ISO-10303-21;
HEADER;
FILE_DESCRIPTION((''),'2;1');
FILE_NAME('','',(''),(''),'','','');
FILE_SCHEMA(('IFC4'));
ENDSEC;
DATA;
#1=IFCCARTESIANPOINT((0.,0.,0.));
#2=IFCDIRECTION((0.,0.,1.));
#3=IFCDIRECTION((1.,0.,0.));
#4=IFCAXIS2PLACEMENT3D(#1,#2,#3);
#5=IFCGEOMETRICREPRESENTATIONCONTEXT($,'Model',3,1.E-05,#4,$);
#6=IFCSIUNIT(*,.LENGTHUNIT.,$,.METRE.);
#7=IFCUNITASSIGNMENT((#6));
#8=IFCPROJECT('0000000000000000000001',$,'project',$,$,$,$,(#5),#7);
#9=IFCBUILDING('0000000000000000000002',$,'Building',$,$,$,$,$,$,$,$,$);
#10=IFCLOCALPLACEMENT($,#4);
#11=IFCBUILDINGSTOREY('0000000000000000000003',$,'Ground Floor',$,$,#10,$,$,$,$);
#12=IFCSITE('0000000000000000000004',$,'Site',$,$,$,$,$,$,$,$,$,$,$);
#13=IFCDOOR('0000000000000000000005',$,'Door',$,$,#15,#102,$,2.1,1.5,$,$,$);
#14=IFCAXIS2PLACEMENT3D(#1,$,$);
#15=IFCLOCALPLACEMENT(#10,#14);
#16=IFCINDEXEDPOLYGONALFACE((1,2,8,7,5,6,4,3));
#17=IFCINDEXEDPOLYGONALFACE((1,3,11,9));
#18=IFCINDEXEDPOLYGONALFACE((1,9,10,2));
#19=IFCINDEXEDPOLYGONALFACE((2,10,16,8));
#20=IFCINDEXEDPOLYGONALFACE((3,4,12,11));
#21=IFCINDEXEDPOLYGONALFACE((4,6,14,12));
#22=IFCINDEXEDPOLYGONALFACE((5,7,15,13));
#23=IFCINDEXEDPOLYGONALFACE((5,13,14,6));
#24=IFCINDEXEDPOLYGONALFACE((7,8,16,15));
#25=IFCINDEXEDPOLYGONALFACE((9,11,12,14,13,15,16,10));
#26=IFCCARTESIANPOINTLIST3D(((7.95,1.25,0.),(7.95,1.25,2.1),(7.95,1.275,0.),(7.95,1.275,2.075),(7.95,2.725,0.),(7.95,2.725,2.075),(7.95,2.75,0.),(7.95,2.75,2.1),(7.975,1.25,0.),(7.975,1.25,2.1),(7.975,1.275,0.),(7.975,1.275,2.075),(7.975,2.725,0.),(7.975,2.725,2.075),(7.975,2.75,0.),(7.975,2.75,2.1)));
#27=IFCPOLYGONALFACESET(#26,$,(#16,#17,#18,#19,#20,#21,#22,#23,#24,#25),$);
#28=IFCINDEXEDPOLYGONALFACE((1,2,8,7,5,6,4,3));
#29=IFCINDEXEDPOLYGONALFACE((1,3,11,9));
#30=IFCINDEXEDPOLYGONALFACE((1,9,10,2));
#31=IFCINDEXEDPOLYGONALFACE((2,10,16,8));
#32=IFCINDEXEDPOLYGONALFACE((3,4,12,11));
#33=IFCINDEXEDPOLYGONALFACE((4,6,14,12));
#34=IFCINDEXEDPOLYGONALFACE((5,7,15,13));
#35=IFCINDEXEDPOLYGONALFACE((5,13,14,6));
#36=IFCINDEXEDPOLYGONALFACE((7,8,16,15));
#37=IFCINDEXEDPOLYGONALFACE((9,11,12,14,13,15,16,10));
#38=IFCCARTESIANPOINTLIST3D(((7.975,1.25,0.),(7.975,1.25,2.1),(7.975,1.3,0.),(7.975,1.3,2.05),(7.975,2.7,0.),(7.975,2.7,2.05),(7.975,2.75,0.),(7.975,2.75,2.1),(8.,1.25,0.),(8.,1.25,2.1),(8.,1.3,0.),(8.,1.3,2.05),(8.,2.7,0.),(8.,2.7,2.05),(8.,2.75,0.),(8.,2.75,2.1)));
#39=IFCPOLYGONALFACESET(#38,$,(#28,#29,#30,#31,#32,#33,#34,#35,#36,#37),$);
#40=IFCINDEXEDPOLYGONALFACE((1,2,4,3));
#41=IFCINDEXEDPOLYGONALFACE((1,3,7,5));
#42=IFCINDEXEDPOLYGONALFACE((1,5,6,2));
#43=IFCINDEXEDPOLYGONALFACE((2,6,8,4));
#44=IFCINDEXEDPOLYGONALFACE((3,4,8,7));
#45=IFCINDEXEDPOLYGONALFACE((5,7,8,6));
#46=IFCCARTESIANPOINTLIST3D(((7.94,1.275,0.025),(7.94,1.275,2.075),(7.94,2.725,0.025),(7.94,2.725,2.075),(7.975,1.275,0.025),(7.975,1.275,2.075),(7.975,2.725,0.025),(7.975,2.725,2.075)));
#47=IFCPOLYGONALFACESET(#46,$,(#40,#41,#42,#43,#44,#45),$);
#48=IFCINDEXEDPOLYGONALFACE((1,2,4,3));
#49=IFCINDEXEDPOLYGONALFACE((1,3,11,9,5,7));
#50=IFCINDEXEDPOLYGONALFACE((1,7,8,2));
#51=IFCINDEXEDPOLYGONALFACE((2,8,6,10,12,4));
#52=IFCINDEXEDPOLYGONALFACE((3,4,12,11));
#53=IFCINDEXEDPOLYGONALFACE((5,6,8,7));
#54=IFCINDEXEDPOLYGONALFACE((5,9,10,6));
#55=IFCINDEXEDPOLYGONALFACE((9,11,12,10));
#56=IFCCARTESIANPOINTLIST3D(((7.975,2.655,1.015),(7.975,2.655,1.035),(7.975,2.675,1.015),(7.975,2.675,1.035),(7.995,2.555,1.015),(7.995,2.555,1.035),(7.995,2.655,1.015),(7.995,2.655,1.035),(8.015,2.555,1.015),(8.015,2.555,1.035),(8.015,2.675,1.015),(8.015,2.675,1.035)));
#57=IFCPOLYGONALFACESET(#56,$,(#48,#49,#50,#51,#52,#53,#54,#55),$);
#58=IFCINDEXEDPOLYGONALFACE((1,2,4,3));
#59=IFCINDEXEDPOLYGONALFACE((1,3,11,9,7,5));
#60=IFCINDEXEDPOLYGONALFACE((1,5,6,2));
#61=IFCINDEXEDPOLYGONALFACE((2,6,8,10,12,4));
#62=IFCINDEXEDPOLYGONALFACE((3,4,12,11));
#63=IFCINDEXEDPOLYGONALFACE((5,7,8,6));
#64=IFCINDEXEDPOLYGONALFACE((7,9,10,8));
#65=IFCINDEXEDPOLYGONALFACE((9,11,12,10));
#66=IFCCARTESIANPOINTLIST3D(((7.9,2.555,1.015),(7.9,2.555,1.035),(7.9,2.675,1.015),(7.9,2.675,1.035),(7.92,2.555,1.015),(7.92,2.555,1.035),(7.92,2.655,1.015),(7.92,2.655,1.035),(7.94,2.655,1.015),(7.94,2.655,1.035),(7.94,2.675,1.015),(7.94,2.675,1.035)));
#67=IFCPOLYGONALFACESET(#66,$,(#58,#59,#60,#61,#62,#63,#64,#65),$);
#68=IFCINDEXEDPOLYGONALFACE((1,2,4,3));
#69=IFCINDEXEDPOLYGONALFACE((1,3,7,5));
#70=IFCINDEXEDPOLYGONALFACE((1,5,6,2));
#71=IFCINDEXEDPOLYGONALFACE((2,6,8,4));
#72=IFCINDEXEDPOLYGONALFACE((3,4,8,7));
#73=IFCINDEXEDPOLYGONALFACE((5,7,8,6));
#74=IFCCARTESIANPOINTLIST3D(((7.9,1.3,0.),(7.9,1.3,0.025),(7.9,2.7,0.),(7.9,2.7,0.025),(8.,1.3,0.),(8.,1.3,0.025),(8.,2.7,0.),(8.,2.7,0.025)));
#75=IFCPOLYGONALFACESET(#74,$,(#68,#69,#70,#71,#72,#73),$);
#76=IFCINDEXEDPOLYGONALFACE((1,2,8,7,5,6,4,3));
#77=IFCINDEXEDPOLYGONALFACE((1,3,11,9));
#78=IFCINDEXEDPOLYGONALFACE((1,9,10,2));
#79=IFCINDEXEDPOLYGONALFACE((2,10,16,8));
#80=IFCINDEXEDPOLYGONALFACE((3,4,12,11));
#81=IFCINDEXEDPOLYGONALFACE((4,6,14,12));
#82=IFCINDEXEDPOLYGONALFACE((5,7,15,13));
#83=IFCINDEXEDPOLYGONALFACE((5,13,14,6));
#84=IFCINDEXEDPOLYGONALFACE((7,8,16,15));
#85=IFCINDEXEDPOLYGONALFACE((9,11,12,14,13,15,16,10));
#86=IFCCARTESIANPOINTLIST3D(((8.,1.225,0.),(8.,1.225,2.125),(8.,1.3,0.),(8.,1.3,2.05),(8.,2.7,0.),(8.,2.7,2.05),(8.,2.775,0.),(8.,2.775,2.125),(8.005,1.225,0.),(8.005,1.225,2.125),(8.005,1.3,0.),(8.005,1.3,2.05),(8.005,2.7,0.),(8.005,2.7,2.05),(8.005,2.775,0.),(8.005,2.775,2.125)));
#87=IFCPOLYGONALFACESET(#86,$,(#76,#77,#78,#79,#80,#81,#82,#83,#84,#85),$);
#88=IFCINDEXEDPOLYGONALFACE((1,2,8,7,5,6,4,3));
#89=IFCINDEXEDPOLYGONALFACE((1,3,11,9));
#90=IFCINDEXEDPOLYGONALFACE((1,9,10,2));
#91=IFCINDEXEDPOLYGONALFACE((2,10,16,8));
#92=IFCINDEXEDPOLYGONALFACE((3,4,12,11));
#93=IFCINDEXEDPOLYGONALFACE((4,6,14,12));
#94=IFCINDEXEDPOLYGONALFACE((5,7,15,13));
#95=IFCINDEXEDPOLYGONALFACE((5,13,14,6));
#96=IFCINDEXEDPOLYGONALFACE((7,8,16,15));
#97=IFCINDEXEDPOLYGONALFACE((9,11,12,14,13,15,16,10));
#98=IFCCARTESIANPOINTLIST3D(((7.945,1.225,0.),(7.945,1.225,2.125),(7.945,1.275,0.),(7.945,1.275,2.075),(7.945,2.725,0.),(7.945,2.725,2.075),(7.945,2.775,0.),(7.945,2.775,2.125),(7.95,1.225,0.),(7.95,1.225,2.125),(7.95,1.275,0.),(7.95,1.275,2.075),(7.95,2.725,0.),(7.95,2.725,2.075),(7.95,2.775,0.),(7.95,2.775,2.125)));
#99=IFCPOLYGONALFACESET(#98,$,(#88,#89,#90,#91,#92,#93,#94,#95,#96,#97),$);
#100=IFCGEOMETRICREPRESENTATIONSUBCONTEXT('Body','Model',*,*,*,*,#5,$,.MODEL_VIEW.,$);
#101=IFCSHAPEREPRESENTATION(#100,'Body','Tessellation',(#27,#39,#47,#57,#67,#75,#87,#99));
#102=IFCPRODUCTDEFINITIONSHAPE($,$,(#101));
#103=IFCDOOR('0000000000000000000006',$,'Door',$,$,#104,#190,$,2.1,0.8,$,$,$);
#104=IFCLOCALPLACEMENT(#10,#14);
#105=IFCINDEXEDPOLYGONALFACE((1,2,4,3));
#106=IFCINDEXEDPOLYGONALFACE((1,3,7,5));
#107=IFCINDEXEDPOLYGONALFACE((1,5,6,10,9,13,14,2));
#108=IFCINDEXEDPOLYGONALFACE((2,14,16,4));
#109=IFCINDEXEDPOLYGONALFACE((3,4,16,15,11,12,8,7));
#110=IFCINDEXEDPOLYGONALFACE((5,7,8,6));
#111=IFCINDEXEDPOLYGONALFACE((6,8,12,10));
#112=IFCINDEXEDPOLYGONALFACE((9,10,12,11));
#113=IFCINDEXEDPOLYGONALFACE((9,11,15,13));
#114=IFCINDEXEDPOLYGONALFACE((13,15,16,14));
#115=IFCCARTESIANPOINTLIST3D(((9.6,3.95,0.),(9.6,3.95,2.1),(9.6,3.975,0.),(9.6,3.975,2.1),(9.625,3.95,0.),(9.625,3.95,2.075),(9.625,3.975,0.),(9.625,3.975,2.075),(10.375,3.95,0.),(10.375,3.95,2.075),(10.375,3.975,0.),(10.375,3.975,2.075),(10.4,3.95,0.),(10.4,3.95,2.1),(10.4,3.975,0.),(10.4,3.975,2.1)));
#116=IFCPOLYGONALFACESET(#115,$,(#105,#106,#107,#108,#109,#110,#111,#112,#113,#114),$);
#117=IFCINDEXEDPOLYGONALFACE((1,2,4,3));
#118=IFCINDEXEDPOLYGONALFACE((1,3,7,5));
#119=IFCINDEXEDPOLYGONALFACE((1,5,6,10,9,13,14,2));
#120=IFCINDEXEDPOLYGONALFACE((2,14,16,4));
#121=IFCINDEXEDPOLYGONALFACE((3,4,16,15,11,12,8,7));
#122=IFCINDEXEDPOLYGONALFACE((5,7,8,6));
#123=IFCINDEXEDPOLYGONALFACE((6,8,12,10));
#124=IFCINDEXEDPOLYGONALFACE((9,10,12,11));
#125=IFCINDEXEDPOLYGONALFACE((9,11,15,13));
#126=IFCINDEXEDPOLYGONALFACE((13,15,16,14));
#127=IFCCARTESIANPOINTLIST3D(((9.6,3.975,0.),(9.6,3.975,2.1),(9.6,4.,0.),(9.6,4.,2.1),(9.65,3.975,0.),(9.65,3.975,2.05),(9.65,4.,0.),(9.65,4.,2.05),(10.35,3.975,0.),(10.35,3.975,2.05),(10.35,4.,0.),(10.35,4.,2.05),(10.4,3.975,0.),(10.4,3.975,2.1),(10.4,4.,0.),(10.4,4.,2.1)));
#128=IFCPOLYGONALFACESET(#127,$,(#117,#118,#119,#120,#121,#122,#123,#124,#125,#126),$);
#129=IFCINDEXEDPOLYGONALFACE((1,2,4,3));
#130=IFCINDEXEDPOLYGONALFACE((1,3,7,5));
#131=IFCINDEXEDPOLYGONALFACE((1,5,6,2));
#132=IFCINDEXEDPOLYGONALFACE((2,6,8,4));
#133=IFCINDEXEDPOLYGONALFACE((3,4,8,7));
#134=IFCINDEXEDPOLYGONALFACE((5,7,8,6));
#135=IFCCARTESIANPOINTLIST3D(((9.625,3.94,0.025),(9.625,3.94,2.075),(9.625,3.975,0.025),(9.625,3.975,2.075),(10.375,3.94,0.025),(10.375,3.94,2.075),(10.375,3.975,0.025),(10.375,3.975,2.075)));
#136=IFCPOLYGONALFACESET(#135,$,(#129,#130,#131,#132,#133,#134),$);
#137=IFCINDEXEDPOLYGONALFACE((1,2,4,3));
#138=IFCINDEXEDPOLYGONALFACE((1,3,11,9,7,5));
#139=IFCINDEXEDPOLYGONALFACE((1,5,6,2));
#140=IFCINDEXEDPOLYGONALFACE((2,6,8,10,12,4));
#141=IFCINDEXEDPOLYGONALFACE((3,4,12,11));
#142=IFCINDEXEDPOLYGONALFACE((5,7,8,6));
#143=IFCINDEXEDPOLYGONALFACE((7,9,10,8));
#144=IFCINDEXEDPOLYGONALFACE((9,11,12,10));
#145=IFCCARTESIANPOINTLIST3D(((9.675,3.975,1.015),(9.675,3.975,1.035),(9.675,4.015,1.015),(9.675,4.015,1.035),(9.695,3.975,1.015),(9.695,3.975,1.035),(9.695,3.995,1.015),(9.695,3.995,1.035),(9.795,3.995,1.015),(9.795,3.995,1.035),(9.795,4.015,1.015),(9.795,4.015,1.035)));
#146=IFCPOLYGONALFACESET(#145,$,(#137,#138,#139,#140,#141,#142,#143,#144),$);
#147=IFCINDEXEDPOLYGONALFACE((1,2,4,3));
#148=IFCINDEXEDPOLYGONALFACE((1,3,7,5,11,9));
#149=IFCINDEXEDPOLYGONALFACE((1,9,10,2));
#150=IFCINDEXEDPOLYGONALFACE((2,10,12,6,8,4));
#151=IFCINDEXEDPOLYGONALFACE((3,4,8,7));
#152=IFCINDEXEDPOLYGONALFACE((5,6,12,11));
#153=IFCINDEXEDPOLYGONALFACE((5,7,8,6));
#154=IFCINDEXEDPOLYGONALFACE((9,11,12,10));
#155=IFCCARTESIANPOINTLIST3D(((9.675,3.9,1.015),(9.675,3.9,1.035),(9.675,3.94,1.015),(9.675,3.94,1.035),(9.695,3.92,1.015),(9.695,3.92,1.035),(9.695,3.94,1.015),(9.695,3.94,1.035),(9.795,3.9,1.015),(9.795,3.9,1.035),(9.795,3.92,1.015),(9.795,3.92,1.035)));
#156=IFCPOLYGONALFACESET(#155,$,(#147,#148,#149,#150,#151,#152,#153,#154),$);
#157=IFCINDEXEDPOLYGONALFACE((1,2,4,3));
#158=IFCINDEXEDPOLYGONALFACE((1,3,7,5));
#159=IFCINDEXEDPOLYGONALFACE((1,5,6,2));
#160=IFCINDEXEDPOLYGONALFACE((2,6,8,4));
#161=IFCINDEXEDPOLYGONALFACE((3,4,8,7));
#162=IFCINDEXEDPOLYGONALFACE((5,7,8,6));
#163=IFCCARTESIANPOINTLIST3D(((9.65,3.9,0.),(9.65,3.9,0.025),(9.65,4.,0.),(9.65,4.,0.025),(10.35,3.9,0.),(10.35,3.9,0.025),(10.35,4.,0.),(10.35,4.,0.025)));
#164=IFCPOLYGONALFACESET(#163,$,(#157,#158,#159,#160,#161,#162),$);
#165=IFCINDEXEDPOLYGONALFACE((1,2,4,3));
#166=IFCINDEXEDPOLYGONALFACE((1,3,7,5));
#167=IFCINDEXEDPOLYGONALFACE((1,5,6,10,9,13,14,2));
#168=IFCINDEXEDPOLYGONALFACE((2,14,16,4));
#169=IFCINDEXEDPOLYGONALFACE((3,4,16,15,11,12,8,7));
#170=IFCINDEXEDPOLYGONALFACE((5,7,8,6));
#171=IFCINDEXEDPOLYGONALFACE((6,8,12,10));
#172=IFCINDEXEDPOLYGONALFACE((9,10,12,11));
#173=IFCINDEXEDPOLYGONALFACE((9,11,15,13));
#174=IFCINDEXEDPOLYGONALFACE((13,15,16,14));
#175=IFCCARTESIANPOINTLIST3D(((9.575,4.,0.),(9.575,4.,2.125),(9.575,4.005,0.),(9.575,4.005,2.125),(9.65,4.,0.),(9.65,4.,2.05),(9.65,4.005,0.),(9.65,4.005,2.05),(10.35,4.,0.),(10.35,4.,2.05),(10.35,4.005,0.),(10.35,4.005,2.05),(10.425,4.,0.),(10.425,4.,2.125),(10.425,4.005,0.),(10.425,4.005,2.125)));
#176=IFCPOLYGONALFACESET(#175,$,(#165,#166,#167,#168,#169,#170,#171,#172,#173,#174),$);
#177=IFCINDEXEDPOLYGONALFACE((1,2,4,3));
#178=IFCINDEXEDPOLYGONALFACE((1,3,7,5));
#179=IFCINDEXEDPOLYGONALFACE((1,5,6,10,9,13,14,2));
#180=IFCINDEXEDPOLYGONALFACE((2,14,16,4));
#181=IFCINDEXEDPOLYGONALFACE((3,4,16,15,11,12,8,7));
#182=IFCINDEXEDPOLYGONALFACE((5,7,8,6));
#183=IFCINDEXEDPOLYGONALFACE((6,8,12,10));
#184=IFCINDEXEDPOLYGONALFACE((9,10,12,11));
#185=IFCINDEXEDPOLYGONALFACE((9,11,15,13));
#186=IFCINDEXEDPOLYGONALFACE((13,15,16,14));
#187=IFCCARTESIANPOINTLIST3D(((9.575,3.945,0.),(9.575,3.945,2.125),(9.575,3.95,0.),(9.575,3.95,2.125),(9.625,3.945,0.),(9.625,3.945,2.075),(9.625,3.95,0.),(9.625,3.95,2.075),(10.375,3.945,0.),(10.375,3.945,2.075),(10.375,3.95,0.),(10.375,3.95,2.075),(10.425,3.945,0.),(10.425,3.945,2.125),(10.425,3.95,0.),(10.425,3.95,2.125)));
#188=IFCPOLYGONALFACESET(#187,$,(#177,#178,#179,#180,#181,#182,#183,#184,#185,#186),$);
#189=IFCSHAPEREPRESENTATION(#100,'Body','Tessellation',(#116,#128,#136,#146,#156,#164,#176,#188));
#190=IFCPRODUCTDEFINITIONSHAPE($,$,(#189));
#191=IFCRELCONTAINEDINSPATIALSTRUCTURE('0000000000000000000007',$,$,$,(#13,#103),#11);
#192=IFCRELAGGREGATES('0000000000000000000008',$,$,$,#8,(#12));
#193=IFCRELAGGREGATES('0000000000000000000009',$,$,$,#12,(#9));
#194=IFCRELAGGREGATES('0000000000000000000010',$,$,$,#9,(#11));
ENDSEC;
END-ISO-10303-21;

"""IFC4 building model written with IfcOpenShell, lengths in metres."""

from ifc_helpers import new_model, si_unit, frame, origin_with_axes, place, context, subcontext, project, spatial, line, indexed_curve, outline, extrude, element, save


model = new_model("IFC4")

# Units and contexts
model_context = context("Model", 3, precision=1e-05, world=origin_with_axes())
body_context = subcontext(model_context, "Body", "Model", "MODEL_VIEW")
ifc_project = project(units=[si_unit("LENGTHUNIT", "METRE")], contexts=[model_context])

# Site, building, storey
site = spatial("IfcSite", under=ifc_project, Name="Site")
building = spatial("IfcBuilding", under=site, Name="Building")
storey_placement = place(None, origin_with_axes())
storey = spatial("IfcBuildingStorey", under=building, at=storey_placement, Name="Ground Floor")

# Doors
door_1_placement = place(storey_placement, frame((8.0, 1.25, 0.0), z_axis=(0.0, 0.0, 1.0), x_axis=(0.0, 1.0, 0.0)))
element("IfcDoor", 1, at=door_1_placement, inside=storey, Name="Door", OverallHeight=2.1, OverallWidth=1.5, context=body_context, shape_type="SweptSolid", body=[
    extrude(outline(indexed_curve([(0.0, 0.0), (0.0, 2.1), (1.5, 2.1), (1.5, 0.0), (1.475, 0.0), (1.475, 2.075), (0.025, 2.075), (0.025, 0.0)], segments=[line(1, 2, 3, 4, 5, 6, 7, 8, 1)])), frame((0.0, 0.025, 0.0), z_axis=(0.0, -1.0, 0.0), x_axis=(1.0, 0.0, 0.0)), (0.0, 0.0, -1.0), 0.025),
    extrude(outline(indexed_curve([(0.0, 0.0), (0.0, 2.1), (1.5, 2.1), (1.5, 0.0), (1.45, 0.0), (1.45, 2.05), (0.05, 2.05), (0.05, 0.0)], segments=[line(1, 2, 3, 4, 5, 6, 7, 8, 1)])), frame((0.0, 0.0, 0.0), z_axis=(0.0, -1.0, 0.0), x_axis=(1.0, 0.0, 0.0)), (0.0, 0.0, -1.0), 0.025),
    extrude(outline(indexed_curve([(0.0, 0.0), (1.45, 0.0), (1.45, 0.035), (0.0, 0.035)], segments=[line(1, 2, 3, 4, 1)])), frame((0.025, 0.025, 0.025), z_axis=(0.0, 0.0, 1.0), x_axis=(1.0, 0.0, 0.0)), (0.0, 0.0, 1.0), 2.05),
    extrude(outline(indexed_curve([(0.0, 0.0), (0.0, -0.04), (-0.12, -0.04), (-0.12, -0.02), (-0.02, -0.02), (-0.02, 0.0)], segments=[line(1, 2, 3, 4, 5, 6, 1)])), frame((1.425, 0.025, 1.015), z_axis=(0.0, 0.0, 1.0), x_axis=(1.0, 0.0, 0.0)), (0.0, 0.0, 1.0), 0.02),
    extrude(outline(indexed_curve([(0.0, 0.0), (0.0, 0.04), (-0.12, 0.04), (-0.12, 0.02), (-0.02, 0.02), (-0.02, 0.0)], segments=[line(1, 2, 3, 4, 5, 6, 1)])), frame((1.425, 0.06, 1.015), z_axis=(0.0, 0.0, 1.0), x_axis=(1.0, 0.0, 0.0)), (0.0, 0.0, 1.0), 0.02),
    extrude(outline(indexed_curve([(0.0, 0.0), (1.4, 0.0), (1.4, 0.1), (0.0, 0.1)], segments=[line(1, 2, 3, 4, 1)])), frame((0.05, 0.0, 0.0), z_axis=(0.0, 0.0, 1.0), x_axis=(1.0, 0.0, 0.0)), (0.0, 0.0, 1.0), 0.025),
    extrude(outline(indexed_curve([(0.0, 0.0), (0.0, 2.125), (1.55, 2.125), (1.55, 0.0), (1.475, 0.0), (1.475, 2.05), (0.075, 2.05), (0.075, 0.0)], segments=[line(1, 2, 3, 4, 5, 6, 7, 8, 1)])), frame((-0.025, -0.005, 0.0), z_axis=(0.0, -1.0, 0.0), x_axis=(1.0, 0.0, 0.0)), (0.0, 0.0, -1.0), 0.005),
    extrude(outline(indexed_curve([(0.0, 0.0), (0.0, 2.125), (1.55, 2.125), (1.55, 0.0), (1.5, 0.0), (1.5, 2.075), (0.05, 2.075), (0.05, 0.0)], segments=[line(1, 2, 3, 4, 5, 6, 7, 8, 1)])), frame((-0.025, 0.05, 0.0), z_axis=(0.0, -1.0, 0.0), x_axis=(1.0, 0.0, 0.0)), (0.0, 0.0, -1.0), 0.005),
])
door_2_placement = place(storey_placement, frame((10.4, 4.0, 0.0), z_axis=(0.0, 0.0, 1.0), x_axis=(-1.0, 0.0, 0.0)))
element("IfcDoor", 2, at=door_2_placement, inside=storey, Name="Door", OverallHeight=2.1, OverallWidth=0.8, context=body_context, shape_type="SweptSolid", body=[
    extrude(outline(indexed_curve([(0.0, 0.0), (0.0, 2.1), (0.8, 2.1), (0.8, 0.0), (0.775, 0.0), (0.775, 2.075), (0.025, 2.075), (0.025, 0.0)], segments=[line(1, 2, 3, 4, 5, 6, 7, 8, 1)])), frame((0.0, 0.025, 0.0), z_axis=(0.0, -1.0, 0.0), x_axis=(1.0, 0.0, 0.0)), (0.0, 0.0, -1.0), 0.025),
    extrude(outline(indexed_curve([(0.0, 0.0), (0.0, 2.1), (0.8, 2.1), (0.8, 0.0), (0.75, 0.0), (0.75, 2.05), (0.05, 2.05), (0.05, 0.0)], segments=[line(1, 2, 3, 4, 5, 6, 7, 8, 1)])), frame((0.0, 0.0, 0.0), z_axis=(0.0, -1.0, 0.0), x_axis=(1.0, 0.0, 0.0)), (0.0, 0.0, -1.0), 0.025),
    extrude(outline(indexed_curve([(0.0, 0.0), (0.75, 0.0), (0.75, 0.035), (0.0, 0.035)], segments=[line(1, 2, 3, 4, 1)])), frame((0.025, 0.025, 0.025), z_axis=(0.0, 0.0, 1.0), x_axis=(1.0, 0.0, 0.0)), (0.0, 0.0, 1.0), 2.05),
    extrude(outline(indexed_curve([(0.0, 0.0), (0.0, -0.04), (-0.12, -0.04), (-0.12, -0.02), (-0.02, -0.02), (-0.02, 0.0)], segments=[line(1, 2, 3, 4, 5, 6, 1)])), frame((0.725, 0.025, 1.015), z_axis=(0.0, 0.0, 1.0), x_axis=(1.0, 0.0, 0.0)), (0.0, 0.0, 1.0), 0.02),
    extrude(outline(indexed_curve([(0.0, 0.0), (0.0, 0.04), (-0.12, 0.04), (-0.12, 0.02), (-0.02, 0.02), (-0.02, 0.0)], segments=[line(1, 2, 3, 4, 5, 6, 1)])), frame((0.725, 0.06, 1.015), z_axis=(0.0, 0.0, 1.0), x_axis=(1.0, 0.0, 0.0)), (0.0, 0.0, 1.0), 0.02),
    extrude(outline(indexed_curve([(0.0, 0.0), (0.7, 0.0), (0.7, 0.1), (0.0, 0.1)], segments=[line(1, 2, 3, 4, 1)])), frame((0.05, 0.0, 0.0), z_axis=(0.0, 0.0, 1.0), x_axis=(1.0, 0.0, 0.0)), (0.0, 0.0, 1.0), 0.025),
    extrude(outline(indexed_curve([(0.0, 0.0), (0.0, 2.125), (0.85, 2.125), (0.85, 0.0), (0.775, 0.0), (0.775, 2.05), (0.075, 2.05), (0.075, 0.0)], segments=[line(1, 2, 3, 4, 5, 6, 7, 8, 1)])), frame((-0.025, -0.005, 0.0), z_axis=(0.0, -1.0, 0.0), x_axis=(1.0, 0.0, 0.0)), (0.0, 0.0, -1.0), 0.005),
    extrude(outline(indexed_curve([(0.0, 0.0), (0.0, 2.125), (0.85, 2.125), (0.85, 0.0), (0.8, 0.0), (0.8, 2.075), (0.05, 2.075), (0.05, 0.0)], segments=[line(1, 2, 3, 4, 5, 6, 7, 8, 1)])), frame((-0.025, 0.05, 0.0), z_axis=(0.0, -1.0, 0.0), x_axis=(1.0, 0.0, 0.0)), (0.0, 0.0, -1.0), 0.005),
])

save(model, "model.ifc")
